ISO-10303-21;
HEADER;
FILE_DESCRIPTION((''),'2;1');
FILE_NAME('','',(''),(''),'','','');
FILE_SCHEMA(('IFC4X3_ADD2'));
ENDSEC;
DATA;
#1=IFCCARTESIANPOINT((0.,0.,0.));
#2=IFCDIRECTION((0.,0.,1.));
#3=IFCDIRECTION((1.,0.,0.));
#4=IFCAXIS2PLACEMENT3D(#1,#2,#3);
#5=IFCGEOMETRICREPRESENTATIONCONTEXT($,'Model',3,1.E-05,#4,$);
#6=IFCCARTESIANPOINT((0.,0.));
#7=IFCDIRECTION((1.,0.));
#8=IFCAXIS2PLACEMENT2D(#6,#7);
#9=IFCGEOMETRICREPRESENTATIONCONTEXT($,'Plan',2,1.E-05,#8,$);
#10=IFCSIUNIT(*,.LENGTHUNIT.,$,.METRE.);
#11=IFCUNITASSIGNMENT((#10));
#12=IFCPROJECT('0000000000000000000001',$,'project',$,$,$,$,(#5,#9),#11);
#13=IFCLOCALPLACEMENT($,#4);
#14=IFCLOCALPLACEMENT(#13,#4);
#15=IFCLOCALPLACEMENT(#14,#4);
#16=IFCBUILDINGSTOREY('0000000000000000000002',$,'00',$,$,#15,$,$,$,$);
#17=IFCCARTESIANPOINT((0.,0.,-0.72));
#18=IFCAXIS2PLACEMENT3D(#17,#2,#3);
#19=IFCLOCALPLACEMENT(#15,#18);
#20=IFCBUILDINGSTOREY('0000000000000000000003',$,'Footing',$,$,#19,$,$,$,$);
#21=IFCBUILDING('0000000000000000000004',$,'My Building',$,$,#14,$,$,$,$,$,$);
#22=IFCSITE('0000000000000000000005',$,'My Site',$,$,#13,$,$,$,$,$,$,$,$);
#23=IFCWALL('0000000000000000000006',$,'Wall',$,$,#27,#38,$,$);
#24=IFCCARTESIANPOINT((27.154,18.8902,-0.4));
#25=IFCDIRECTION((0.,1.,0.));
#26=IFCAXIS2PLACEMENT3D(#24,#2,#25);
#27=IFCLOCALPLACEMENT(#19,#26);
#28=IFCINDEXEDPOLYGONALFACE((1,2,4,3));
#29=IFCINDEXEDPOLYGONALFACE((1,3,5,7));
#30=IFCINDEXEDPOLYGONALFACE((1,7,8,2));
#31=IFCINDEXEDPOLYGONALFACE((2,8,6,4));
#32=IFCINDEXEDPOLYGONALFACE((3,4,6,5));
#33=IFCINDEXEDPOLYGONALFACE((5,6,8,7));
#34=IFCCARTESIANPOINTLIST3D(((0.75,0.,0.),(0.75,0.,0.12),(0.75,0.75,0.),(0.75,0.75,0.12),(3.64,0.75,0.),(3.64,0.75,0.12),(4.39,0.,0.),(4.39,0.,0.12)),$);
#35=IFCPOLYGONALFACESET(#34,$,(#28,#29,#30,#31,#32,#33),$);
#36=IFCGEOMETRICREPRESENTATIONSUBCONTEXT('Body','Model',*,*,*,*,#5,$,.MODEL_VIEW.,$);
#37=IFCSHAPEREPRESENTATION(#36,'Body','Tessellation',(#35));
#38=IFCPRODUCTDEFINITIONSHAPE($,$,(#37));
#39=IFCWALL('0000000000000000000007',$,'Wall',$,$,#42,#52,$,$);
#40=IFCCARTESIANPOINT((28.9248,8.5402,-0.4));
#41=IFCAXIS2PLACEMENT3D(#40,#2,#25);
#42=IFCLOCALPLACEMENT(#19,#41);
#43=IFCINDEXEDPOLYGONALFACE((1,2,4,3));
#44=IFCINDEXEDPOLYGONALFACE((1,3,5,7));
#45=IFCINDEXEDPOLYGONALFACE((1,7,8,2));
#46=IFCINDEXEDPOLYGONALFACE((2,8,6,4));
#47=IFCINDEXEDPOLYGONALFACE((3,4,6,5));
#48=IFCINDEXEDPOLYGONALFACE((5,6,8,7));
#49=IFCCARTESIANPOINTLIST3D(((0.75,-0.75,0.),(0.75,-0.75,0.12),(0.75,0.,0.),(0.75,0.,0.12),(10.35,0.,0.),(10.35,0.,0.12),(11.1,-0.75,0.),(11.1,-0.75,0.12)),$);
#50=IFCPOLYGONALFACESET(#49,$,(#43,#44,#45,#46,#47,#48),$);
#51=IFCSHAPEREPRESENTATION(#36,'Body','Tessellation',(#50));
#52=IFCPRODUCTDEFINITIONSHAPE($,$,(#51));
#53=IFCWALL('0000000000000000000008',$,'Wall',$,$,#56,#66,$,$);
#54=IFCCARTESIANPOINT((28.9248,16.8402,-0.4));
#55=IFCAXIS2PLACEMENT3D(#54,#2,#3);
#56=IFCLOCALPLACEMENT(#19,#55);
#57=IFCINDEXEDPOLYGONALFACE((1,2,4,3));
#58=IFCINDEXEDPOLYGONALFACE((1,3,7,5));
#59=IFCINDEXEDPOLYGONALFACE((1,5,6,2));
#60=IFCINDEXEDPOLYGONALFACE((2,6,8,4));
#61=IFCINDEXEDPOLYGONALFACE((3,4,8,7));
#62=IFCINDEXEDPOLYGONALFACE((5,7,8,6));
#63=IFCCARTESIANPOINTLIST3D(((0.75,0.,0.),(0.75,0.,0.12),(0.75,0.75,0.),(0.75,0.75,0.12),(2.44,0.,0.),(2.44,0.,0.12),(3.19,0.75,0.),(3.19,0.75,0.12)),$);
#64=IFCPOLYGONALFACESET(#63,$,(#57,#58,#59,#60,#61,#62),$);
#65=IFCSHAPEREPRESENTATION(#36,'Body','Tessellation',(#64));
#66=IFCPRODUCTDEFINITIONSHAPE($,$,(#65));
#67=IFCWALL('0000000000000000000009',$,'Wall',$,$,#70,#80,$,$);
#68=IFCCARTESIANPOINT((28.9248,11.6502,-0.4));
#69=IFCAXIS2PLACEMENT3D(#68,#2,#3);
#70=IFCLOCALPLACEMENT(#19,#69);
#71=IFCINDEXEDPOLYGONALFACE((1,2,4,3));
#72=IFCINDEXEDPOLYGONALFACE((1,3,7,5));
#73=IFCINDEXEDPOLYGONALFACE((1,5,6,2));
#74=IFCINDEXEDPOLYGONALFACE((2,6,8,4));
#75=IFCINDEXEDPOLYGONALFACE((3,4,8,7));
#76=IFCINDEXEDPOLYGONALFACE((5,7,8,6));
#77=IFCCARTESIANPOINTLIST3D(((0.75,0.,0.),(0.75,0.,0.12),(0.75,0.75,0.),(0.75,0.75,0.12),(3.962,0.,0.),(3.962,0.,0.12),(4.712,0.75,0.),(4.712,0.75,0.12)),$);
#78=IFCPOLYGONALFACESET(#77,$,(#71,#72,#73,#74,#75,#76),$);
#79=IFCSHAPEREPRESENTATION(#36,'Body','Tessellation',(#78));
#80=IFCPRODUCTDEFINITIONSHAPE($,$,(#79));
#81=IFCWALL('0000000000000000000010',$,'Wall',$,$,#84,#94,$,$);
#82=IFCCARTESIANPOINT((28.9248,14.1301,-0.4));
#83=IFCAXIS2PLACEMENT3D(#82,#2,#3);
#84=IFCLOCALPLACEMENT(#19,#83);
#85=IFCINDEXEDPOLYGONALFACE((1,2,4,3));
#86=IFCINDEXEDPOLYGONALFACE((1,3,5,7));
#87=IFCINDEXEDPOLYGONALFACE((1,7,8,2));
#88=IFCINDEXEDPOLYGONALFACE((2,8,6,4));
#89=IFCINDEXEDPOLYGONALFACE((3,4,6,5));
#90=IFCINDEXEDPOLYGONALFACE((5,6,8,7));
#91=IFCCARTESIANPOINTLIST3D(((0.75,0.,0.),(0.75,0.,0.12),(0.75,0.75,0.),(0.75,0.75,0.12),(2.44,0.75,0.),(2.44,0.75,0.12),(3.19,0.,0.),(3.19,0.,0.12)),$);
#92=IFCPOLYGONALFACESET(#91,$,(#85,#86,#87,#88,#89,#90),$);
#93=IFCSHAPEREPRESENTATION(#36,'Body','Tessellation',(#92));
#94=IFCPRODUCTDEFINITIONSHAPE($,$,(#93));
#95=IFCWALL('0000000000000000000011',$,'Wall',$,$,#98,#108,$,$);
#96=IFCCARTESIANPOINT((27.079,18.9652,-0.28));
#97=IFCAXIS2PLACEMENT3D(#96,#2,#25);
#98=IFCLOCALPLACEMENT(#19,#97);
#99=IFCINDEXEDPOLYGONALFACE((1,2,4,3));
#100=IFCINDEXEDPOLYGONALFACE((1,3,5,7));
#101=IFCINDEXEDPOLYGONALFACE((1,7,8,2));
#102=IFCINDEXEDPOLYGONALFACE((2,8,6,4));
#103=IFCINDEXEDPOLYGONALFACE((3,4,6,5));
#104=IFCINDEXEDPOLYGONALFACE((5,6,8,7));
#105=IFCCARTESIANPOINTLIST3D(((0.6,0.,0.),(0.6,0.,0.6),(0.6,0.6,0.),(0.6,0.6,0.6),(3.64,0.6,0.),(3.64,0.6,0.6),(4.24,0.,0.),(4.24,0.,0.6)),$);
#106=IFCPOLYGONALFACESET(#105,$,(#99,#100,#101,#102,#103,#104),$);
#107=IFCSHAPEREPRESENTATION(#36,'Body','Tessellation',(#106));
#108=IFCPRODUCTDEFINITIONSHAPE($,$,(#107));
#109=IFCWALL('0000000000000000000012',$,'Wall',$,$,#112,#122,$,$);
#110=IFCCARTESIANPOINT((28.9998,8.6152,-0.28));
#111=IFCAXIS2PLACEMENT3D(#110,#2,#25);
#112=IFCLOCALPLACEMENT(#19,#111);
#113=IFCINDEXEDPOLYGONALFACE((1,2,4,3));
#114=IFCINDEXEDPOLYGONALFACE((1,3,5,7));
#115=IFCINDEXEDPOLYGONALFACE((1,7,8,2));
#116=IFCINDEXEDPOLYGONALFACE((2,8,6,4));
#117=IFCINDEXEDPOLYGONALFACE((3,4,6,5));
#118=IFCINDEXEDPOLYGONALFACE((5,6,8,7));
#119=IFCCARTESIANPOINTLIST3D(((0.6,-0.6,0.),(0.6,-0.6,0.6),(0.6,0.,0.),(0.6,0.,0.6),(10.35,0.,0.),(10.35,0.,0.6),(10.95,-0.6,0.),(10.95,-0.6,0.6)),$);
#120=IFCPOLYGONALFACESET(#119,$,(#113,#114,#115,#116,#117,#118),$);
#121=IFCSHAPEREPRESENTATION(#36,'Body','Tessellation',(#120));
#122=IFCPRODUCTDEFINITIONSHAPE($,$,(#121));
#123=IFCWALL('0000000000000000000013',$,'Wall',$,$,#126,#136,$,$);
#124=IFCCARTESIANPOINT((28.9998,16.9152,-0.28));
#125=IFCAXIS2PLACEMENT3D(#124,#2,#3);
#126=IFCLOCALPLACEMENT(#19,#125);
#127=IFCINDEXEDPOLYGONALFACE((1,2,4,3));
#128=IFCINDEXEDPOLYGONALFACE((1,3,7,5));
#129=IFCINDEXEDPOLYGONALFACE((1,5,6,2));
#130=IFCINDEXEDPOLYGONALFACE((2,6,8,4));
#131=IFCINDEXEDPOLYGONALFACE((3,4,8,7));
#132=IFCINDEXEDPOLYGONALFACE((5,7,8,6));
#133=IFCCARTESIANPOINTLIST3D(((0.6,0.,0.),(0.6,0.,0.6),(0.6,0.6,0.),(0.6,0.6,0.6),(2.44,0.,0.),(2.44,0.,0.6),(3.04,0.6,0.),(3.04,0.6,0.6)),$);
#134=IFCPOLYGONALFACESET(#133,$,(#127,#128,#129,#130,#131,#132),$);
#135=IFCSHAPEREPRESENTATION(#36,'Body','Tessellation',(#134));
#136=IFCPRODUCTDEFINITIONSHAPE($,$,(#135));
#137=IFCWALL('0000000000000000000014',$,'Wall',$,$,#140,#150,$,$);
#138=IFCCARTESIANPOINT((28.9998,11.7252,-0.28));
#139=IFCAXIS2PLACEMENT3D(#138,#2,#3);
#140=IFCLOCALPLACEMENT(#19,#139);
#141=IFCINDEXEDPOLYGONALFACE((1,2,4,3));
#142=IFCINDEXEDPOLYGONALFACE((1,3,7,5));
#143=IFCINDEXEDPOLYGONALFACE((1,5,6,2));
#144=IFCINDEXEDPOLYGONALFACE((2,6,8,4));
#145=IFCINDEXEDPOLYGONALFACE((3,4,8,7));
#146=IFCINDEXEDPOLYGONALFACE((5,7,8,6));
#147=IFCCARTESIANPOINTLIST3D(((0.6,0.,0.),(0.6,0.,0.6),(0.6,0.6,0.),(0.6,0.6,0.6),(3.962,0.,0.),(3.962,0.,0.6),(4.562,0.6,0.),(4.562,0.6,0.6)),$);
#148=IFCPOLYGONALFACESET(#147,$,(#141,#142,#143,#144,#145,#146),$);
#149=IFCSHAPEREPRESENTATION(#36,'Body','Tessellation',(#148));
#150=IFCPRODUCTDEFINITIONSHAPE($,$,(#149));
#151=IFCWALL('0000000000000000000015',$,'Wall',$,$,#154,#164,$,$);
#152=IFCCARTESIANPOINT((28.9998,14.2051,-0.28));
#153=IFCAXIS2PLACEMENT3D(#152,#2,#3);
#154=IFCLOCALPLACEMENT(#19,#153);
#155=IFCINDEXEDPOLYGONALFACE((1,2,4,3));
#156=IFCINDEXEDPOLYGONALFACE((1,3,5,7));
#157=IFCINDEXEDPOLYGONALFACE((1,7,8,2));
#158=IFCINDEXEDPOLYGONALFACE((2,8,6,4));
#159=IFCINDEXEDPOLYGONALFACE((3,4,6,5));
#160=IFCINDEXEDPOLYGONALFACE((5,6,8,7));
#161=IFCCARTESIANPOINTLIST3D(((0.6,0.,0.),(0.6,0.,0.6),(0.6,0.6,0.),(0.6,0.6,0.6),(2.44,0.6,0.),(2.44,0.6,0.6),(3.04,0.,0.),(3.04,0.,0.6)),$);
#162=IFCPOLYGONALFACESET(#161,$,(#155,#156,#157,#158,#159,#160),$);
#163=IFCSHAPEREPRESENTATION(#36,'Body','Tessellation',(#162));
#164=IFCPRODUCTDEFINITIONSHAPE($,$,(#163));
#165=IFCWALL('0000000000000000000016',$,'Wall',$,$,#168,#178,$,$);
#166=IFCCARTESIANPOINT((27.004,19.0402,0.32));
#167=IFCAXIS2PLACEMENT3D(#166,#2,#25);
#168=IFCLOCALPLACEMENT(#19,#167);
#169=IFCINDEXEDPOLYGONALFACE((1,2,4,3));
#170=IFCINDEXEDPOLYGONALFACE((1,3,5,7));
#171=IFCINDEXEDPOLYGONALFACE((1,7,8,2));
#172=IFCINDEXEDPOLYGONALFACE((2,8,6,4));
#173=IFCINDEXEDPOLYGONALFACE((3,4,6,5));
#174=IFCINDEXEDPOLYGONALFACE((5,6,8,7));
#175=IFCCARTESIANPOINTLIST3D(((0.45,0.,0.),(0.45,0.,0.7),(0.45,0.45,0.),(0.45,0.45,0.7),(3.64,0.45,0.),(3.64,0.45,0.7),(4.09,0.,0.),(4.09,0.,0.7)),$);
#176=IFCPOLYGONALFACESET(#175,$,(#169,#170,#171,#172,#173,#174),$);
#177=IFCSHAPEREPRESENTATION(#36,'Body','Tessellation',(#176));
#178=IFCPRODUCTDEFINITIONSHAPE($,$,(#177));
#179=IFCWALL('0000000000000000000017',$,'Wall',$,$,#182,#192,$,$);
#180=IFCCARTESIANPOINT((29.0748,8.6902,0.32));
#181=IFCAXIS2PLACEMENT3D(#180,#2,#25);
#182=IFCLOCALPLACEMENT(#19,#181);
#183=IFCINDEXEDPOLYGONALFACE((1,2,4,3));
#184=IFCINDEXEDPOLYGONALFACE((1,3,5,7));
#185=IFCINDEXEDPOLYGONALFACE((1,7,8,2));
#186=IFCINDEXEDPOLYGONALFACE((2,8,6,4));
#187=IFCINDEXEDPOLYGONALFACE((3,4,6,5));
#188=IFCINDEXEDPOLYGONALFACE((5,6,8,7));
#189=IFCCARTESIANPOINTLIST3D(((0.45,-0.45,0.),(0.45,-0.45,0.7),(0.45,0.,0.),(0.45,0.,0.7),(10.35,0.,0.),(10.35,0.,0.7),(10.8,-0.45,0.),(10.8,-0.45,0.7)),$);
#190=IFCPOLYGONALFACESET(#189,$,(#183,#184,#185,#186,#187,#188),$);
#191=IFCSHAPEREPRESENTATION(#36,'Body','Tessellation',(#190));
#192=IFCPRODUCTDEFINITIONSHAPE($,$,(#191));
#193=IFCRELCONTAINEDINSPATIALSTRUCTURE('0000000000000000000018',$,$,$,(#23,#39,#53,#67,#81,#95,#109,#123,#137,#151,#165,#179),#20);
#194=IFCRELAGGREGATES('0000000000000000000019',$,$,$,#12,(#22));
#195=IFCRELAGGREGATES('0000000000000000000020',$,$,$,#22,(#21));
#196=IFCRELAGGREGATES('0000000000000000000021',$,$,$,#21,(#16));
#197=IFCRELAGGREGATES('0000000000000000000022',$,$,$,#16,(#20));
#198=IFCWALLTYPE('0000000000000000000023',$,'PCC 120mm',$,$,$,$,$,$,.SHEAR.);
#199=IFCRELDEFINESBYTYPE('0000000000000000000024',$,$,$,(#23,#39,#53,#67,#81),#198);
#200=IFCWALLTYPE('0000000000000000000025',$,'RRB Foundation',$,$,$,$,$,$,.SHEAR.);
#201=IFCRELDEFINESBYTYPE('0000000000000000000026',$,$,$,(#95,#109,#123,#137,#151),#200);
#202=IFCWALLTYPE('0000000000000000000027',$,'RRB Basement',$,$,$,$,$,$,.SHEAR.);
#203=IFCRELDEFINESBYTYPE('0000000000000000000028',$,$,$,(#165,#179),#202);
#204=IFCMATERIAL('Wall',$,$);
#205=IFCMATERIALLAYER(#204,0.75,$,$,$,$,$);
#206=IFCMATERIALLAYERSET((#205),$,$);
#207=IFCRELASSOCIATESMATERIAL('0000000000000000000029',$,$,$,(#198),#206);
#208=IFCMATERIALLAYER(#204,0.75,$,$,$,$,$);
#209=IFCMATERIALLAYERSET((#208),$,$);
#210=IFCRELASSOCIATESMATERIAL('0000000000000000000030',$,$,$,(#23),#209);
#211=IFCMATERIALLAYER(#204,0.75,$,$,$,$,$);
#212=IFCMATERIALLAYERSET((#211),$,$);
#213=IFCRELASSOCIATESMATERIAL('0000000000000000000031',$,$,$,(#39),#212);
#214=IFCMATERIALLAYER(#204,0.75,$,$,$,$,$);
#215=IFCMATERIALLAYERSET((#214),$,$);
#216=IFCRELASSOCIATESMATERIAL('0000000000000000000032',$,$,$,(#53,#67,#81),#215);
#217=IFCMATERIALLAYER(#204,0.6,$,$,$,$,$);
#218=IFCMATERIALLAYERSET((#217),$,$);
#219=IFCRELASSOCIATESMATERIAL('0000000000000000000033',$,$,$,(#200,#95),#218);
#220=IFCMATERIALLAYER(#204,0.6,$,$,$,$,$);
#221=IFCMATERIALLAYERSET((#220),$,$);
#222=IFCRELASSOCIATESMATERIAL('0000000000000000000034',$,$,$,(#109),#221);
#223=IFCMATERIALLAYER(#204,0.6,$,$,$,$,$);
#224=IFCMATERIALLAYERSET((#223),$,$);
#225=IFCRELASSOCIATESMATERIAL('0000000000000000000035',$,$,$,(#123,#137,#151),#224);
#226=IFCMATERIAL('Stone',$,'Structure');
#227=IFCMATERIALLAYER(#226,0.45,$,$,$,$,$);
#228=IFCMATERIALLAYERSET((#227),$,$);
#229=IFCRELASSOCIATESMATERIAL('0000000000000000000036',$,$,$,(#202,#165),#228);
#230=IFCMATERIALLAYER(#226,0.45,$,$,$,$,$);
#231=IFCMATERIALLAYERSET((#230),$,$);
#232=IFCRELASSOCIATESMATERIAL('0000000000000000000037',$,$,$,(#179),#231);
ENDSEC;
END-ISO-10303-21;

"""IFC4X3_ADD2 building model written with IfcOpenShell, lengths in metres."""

from ifc_helpers import new_model, si_unit, frame, origin_with_axes, origin_2d_with_axis, place, context, subcontext, project, spatial, line, indexed_curve, outline, extrude, material, layer, layer_set, layer_usage, type_object, element, save


model = new_model("IFC4X3_ADD2")

# Units and contexts
model_context = context("Model", 3, precision=1e-05, world=origin_with_axes())
plan_context = context("Plan", 2, precision=1e-05, world=origin_2d_with_axis())
body_context = subcontext(model_context, "Body", "Model", "MODEL_VIEW")
ifc_project = project(units=[si_unit("LENGTHUNIT", "METRE")], contexts=[model_context, plan_context])

# Site, building, storeys
site_placement = place(None, origin_with_axes())
site = spatial("IfcSite", under=ifc_project, at=site_placement, Name="My Site")
building_placement = place(site_placement, origin_with_axes())
building = spatial("IfcBuilding", under=site, at=building_placement, Name="My Building")
storey_1_placement = place(building_placement, origin_with_axes())
storey_1 = spatial("IfcBuildingStorey", under=building, at=storey_1_placement, Name="00")
storey_2_placement = place(storey_1_placement, frame((0.0, 0.0, -0.72), z_axis=(0.0, 0.0, 1.0), x_axis=(1.0, 0.0, 0.0)))
storey_2 = spatial("IfcBuildingStorey", under=storey_1, at=storey_2_placement, Name="Footing")

# Shared definitions
ifc_material_1 = material(Name="Wall")

# Walls
ifc_layer_1 = layer(ifc_material_1, 0.75)
ifc_layer_set_1 = layer_set([ifc_layer_1])
ifc_layer_usage_1 = layer_usage(ifc_layer_set_1, "AXIS2", "POSITIVE", 0.0)
ifc_layer_2 = layer(ifc_material_1, 0.75)
ifc_layer_set_2 = layer_set([ifc_layer_2])
wall_type_1 = type_object("IfcWallType", Name="PCC 120mm", PredefinedType="SHEAR", material=ifc_layer_set_2)
wall_1_placement = place(storey_2_placement, frame((27.154, 18.8902, -0.4), z_axis=(0.0, 0.0, 1.0), x_axis=(0.0, 1.0, 0.0)))
element("IfcWall", 1, at=wall_1_placement, inside=storey_2, type_object=wall_type_1, material=ifc_layer_usage_1, Name="Wall", context=body_context, shape_type="SweptSolid", body=[
    extrude(outline(indexed_curve([(0.75, 0.0), (0.75, 0.75), (3.64, 0.75), (4.39, 0.0)], segments=[line(1, 2, 3, 4, 1)])), origin_with_axes(), (0.0, 0.0, 1.0), 0.12),
])
ifc_layer_3 = layer(ifc_material_1, 0.75)
ifc_layer_set_3 = layer_set([ifc_layer_3])
ifc_layer_usage_2 = layer_usage(ifc_layer_set_3, "AXIS2", "NEGATIVE", 0.0)
wall_2_placement = place(storey_2_placement, frame((28.9248, 8.5402, -0.4), z_axis=(0.0, 0.0, 1.0), x_axis=(0.0, 1.0, 0.0)))
element("IfcWall", 2, at=wall_2_placement, inside=storey_2, type_object=wall_type_1, material=ifc_layer_usage_2, Name="Wall", context=body_context, shape_type="SweptSolid", body=[
    extrude(outline(indexed_curve([(0.75, -0.75), (0.75, 0.0), (10.35, 0.0), (11.1, -0.75)], segments=[line(1, 2, 3, 4, 1)])), origin_with_axes(), (0.0, 0.0, 1.0), 0.12),
])
ifc_layer_4 = layer(ifc_material_1, 0.75)
ifc_layer_set_4 = layer_set([ifc_layer_4])
ifc_layer_usage_3 = layer_usage(ifc_layer_set_4, "AXIS2", "POSITIVE", 0.0)
wall_3_placement = place(storey_2_placement, frame((28.9248, 16.8402, -0.4), z_axis=(0.0, 0.0, 1.0), x_axis=(1.0, 0.0, 0.0)))
element("IfcWall", 3, at=wall_3_placement, inside=storey_2, type_object=wall_type_1, material=ifc_layer_usage_3, Name="Wall", context=body_context, shape_type="SweptSolid", body=[
    extrude(outline(indexed_curve([(0.75, 0.0), (0.75, 0.75), (3.19, 0.75), (2.44, 0.0)], segments=[line(1, 2, 3, 4, 1)])), origin_with_axes(), (0.0, 0.0, 1.0), 0.12),
])
ifc_layer_usage_4 = layer_usage(ifc_layer_set_4, "AXIS2", "POSITIVE", 0.0)
wall_4_placement = place(storey_2_placement, frame((28.9248, 11.6502, -0.4), z_axis=(0.0, 0.0, 1.0), x_axis=(1.0, 0.0, 0.0)))
element("IfcWall", 4, at=wall_4_placement, inside=storey_2, type_object=wall_type_1, material=ifc_layer_usage_4, Name="Wall", context=body_context, shape_type="SweptSolid", body=[
    extrude(outline(indexed_curve([(0.75, 0.0), (0.75, 0.75), (4.712, 0.75), (3.962, 0.0)], segments=[line(1, 2, 3, 4, 1)])), origin_with_axes(), (0.0, 0.0, 1.0), 0.12),
])
ifc_layer_usage_5 = layer_usage(ifc_layer_set_4, "AXIS2", "POSITIVE", 0.0)
wall_5_placement = place(storey_2_placement, frame((28.9248, 14.1301, -0.4), z_axis=(0.0, 0.0, 1.0), x_axis=(1.0, 0.0, 0.0)))
element("IfcWall", 5, at=wall_5_placement, inside=storey_2, type_object=wall_type_1, material=ifc_layer_usage_5, Name="Wall", context=body_context, shape_type="SweptSolid", body=[
    extrude(outline(indexed_curve([(0.75, 0.0), (0.75, 0.75), (2.44, 0.75), (3.19, 0.0)], segments=[line(1, 2, 3, 4, 1)])), origin_with_axes(), (0.0, 0.0, 1.0), 0.12),
])
ifc_layer_5 = layer(ifc_material_1, 0.6)
ifc_layer_set_5 = layer_set([ifc_layer_5])
ifc_layer_usage_6 = layer_usage(ifc_layer_set_5, "AXIS2", "POSITIVE", 0.0)
wall_type_2 = type_object("IfcWallType", Name="RRB Foundation", PredefinedType="SHEAR", material=ifc_layer_set_5)
wall_6_placement = place(storey_2_placement, frame((27.079, 18.9652, -0.28), z_axis=(0.0, 0.0, 1.0), x_axis=(0.0, 1.0, 0.0)))
element("IfcWall", 6, at=wall_6_placement, inside=storey_2, type_object=wall_type_2, material=ifc_layer_usage_6, Name="Wall", context=body_context, shape_type="SweptSolid", body=[
    extrude(outline(indexed_curve([(0.6, 0.0), (0.6, 0.6), (3.64, 0.6), (4.24, 0.0)], segments=[line(1, 2, 3, 4, 1)])), origin_with_axes(), (0.0, 0.0, 1.0), 0.6),
])
ifc_layer_6 = layer(ifc_material_1, 0.6)
ifc_layer_set_6 = layer_set([ifc_layer_6])
ifc_layer_usage_7 = layer_usage(ifc_layer_set_6, "AXIS2", "NEGATIVE", 0.0)
wall_7_placement = place(storey_2_placement, frame((28.9998, 8.6152, -0.28), z_axis=(0.0, 0.0, 1.0), x_axis=(0.0, 1.0, 0.0)))
element("IfcWall", 7, at=wall_7_placement, inside=storey_2, type_object=wall_type_2, material=ifc_layer_usage_7, Name="Wall", context=body_context, shape_type="SweptSolid", body=[
    extrude(outline(indexed_curve([(0.6, -0.6), (0.6, 0.0), (10.35, 0.0), (10.95, -0.6)], segments=[line(1, 2, 3, 4, 1)])), origin_with_axes(), (0.0, 0.0, 1.0), 0.6),
])
ifc_layer_7 = layer(ifc_material_1, 0.6)
ifc_layer_set_7 = layer_set([ifc_layer_7])
ifc_layer_usage_8 = layer_usage(ifc_layer_set_7, "AXIS2", "POSITIVE", 0.0)
wall_8_placement = place(storey_2_placement, frame((28.9998, 16.9152, -0.28), z_axis=(0.0, 0.0, 1.0), x_axis=(1.0, 0.0, 0.0)))
element("IfcWall", 8, at=wall_8_placement, inside=storey_2, type_object=wall_type_2, material=ifc_layer_usage_8, Name="Wall", context=body_context, shape_type="SweptSolid", body=[
    extrude(outline(indexed_curve([(0.6, 0.0), (0.6, 0.6), (3.04, 0.6), (2.44, 0.0)], segments=[line(1, 2, 3, 4, 1)])), origin_with_axes(), (0.0, 0.0, 1.0), 0.6),
])
ifc_layer_usage_9 = layer_usage(ifc_layer_set_7, "AXIS2", "POSITIVE", 0.0)
wall_9_placement = place(storey_2_placement, frame((28.9998, 11.7252, -0.28), z_axis=(0.0, 0.0, 1.0), x_axis=(1.0, 0.0, 0.0)))
element("IfcWall", 9, at=wall_9_placement, inside=storey_2, type_object=wall_type_2, material=ifc_layer_usage_9, Name="Wall", context=body_context, shape_type="SweptSolid", body=[
    extrude(outline(indexed_curve([(0.6, 0.0), (0.6, 0.6), (4.562, 0.6), (3.962, 0.0)], segments=[line(1, 2, 3, 4, 1)])), origin_with_axes(), (0.0, 0.0, 1.0), 0.6),
])
ifc_layer_usage_10 = layer_usage(ifc_layer_set_7, "AXIS2", "POSITIVE", 0.0)
wall_10_placement = place(storey_2_placement, frame((28.9998, 14.2051, -0.28), z_axis=(0.0, 0.0, 1.0), x_axis=(1.0, 0.0, 0.0)))
element("IfcWall", 10, at=wall_10_placement, inside=storey_2, type_object=wall_type_2, material=ifc_layer_usage_10, Name="Wall", context=body_context, shape_type="SweptSolid", body=[
    extrude(outline(indexed_curve([(0.6, 0.0), (0.6, 0.6), (2.44, 0.6), (3.04, 0.0)], segments=[line(1, 2, 3, 4, 1)])), origin_with_axes(), (0.0, 0.0, 1.0), 0.6),
])
ifc_material_2 = material(Name="Stone", Category="Structure")
ifc_layer_8 = layer(ifc_material_2, 0.45)
ifc_layer_set_8 = layer_set([ifc_layer_8])
ifc_layer_usage_11 = layer_usage(ifc_layer_set_8, "AXIS2", "POSITIVE", 0.0)
wall_type_3 = type_object("IfcWallType", Name="RRB Basement", PredefinedType="SHEAR", material=ifc_layer_set_8)
wall_11_placement = place(storey_2_placement, frame((27.004, 19.0402, 0.32), z_axis=(0.0, 0.0, 1.0), x_axis=(0.0, 1.0, 0.0)))
element("IfcWall", 11, at=wall_11_placement, inside=storey_2, type_object=wall_type_3, material=ifc_layer_usage_11, Name="Wall", context=body_context, shape_type="SweptSolid", body=[
    extrude(outline(indexed_curve([(0.45, 0.0), (0.45, 0.45), (3.64, 0.45), (4.09, 0.0)], segments=[line(1, 2, 3, 4, 1)])), origin_with_axes(), (0.0, 0.0, 1.0), 0.7),
])
ifc_layer_9 = layer(ifc_material_2, 0.45)
ifc_layer_set_9 = layer_set([ifc_layer_9])
ifc_layer_usage_12 = layer_usage(ifc_layer_set_9, "AXIS2", "NEGATIVE", 0.0)
wall_12_placement = place(storey_2_placement, frame((29.0748, 8.6902, 0.32), z_axis=(0.0, 0.0, 1.0), x_axis=(0.0, 1.0, 0.0)))
element("IfcWall", 12, at=wall_12_placement, inside=storey_2, type_object=wall_type_3, material=ifc_layer_usage_12, Name="Wall", context=body_context, shape_type="SweptSolid", body=[
    extrude(outline(indexed_curve([(0.45, -0.45), (0.45, 0.0), (10.35, 0.0), (10.8, -0.45)], segments=[line(1, 2, 3, 4, 1)])), origin_with_axes(), (0.0, 0.0, 1.0), 0.7),
])

save(model, "model.ifc")
